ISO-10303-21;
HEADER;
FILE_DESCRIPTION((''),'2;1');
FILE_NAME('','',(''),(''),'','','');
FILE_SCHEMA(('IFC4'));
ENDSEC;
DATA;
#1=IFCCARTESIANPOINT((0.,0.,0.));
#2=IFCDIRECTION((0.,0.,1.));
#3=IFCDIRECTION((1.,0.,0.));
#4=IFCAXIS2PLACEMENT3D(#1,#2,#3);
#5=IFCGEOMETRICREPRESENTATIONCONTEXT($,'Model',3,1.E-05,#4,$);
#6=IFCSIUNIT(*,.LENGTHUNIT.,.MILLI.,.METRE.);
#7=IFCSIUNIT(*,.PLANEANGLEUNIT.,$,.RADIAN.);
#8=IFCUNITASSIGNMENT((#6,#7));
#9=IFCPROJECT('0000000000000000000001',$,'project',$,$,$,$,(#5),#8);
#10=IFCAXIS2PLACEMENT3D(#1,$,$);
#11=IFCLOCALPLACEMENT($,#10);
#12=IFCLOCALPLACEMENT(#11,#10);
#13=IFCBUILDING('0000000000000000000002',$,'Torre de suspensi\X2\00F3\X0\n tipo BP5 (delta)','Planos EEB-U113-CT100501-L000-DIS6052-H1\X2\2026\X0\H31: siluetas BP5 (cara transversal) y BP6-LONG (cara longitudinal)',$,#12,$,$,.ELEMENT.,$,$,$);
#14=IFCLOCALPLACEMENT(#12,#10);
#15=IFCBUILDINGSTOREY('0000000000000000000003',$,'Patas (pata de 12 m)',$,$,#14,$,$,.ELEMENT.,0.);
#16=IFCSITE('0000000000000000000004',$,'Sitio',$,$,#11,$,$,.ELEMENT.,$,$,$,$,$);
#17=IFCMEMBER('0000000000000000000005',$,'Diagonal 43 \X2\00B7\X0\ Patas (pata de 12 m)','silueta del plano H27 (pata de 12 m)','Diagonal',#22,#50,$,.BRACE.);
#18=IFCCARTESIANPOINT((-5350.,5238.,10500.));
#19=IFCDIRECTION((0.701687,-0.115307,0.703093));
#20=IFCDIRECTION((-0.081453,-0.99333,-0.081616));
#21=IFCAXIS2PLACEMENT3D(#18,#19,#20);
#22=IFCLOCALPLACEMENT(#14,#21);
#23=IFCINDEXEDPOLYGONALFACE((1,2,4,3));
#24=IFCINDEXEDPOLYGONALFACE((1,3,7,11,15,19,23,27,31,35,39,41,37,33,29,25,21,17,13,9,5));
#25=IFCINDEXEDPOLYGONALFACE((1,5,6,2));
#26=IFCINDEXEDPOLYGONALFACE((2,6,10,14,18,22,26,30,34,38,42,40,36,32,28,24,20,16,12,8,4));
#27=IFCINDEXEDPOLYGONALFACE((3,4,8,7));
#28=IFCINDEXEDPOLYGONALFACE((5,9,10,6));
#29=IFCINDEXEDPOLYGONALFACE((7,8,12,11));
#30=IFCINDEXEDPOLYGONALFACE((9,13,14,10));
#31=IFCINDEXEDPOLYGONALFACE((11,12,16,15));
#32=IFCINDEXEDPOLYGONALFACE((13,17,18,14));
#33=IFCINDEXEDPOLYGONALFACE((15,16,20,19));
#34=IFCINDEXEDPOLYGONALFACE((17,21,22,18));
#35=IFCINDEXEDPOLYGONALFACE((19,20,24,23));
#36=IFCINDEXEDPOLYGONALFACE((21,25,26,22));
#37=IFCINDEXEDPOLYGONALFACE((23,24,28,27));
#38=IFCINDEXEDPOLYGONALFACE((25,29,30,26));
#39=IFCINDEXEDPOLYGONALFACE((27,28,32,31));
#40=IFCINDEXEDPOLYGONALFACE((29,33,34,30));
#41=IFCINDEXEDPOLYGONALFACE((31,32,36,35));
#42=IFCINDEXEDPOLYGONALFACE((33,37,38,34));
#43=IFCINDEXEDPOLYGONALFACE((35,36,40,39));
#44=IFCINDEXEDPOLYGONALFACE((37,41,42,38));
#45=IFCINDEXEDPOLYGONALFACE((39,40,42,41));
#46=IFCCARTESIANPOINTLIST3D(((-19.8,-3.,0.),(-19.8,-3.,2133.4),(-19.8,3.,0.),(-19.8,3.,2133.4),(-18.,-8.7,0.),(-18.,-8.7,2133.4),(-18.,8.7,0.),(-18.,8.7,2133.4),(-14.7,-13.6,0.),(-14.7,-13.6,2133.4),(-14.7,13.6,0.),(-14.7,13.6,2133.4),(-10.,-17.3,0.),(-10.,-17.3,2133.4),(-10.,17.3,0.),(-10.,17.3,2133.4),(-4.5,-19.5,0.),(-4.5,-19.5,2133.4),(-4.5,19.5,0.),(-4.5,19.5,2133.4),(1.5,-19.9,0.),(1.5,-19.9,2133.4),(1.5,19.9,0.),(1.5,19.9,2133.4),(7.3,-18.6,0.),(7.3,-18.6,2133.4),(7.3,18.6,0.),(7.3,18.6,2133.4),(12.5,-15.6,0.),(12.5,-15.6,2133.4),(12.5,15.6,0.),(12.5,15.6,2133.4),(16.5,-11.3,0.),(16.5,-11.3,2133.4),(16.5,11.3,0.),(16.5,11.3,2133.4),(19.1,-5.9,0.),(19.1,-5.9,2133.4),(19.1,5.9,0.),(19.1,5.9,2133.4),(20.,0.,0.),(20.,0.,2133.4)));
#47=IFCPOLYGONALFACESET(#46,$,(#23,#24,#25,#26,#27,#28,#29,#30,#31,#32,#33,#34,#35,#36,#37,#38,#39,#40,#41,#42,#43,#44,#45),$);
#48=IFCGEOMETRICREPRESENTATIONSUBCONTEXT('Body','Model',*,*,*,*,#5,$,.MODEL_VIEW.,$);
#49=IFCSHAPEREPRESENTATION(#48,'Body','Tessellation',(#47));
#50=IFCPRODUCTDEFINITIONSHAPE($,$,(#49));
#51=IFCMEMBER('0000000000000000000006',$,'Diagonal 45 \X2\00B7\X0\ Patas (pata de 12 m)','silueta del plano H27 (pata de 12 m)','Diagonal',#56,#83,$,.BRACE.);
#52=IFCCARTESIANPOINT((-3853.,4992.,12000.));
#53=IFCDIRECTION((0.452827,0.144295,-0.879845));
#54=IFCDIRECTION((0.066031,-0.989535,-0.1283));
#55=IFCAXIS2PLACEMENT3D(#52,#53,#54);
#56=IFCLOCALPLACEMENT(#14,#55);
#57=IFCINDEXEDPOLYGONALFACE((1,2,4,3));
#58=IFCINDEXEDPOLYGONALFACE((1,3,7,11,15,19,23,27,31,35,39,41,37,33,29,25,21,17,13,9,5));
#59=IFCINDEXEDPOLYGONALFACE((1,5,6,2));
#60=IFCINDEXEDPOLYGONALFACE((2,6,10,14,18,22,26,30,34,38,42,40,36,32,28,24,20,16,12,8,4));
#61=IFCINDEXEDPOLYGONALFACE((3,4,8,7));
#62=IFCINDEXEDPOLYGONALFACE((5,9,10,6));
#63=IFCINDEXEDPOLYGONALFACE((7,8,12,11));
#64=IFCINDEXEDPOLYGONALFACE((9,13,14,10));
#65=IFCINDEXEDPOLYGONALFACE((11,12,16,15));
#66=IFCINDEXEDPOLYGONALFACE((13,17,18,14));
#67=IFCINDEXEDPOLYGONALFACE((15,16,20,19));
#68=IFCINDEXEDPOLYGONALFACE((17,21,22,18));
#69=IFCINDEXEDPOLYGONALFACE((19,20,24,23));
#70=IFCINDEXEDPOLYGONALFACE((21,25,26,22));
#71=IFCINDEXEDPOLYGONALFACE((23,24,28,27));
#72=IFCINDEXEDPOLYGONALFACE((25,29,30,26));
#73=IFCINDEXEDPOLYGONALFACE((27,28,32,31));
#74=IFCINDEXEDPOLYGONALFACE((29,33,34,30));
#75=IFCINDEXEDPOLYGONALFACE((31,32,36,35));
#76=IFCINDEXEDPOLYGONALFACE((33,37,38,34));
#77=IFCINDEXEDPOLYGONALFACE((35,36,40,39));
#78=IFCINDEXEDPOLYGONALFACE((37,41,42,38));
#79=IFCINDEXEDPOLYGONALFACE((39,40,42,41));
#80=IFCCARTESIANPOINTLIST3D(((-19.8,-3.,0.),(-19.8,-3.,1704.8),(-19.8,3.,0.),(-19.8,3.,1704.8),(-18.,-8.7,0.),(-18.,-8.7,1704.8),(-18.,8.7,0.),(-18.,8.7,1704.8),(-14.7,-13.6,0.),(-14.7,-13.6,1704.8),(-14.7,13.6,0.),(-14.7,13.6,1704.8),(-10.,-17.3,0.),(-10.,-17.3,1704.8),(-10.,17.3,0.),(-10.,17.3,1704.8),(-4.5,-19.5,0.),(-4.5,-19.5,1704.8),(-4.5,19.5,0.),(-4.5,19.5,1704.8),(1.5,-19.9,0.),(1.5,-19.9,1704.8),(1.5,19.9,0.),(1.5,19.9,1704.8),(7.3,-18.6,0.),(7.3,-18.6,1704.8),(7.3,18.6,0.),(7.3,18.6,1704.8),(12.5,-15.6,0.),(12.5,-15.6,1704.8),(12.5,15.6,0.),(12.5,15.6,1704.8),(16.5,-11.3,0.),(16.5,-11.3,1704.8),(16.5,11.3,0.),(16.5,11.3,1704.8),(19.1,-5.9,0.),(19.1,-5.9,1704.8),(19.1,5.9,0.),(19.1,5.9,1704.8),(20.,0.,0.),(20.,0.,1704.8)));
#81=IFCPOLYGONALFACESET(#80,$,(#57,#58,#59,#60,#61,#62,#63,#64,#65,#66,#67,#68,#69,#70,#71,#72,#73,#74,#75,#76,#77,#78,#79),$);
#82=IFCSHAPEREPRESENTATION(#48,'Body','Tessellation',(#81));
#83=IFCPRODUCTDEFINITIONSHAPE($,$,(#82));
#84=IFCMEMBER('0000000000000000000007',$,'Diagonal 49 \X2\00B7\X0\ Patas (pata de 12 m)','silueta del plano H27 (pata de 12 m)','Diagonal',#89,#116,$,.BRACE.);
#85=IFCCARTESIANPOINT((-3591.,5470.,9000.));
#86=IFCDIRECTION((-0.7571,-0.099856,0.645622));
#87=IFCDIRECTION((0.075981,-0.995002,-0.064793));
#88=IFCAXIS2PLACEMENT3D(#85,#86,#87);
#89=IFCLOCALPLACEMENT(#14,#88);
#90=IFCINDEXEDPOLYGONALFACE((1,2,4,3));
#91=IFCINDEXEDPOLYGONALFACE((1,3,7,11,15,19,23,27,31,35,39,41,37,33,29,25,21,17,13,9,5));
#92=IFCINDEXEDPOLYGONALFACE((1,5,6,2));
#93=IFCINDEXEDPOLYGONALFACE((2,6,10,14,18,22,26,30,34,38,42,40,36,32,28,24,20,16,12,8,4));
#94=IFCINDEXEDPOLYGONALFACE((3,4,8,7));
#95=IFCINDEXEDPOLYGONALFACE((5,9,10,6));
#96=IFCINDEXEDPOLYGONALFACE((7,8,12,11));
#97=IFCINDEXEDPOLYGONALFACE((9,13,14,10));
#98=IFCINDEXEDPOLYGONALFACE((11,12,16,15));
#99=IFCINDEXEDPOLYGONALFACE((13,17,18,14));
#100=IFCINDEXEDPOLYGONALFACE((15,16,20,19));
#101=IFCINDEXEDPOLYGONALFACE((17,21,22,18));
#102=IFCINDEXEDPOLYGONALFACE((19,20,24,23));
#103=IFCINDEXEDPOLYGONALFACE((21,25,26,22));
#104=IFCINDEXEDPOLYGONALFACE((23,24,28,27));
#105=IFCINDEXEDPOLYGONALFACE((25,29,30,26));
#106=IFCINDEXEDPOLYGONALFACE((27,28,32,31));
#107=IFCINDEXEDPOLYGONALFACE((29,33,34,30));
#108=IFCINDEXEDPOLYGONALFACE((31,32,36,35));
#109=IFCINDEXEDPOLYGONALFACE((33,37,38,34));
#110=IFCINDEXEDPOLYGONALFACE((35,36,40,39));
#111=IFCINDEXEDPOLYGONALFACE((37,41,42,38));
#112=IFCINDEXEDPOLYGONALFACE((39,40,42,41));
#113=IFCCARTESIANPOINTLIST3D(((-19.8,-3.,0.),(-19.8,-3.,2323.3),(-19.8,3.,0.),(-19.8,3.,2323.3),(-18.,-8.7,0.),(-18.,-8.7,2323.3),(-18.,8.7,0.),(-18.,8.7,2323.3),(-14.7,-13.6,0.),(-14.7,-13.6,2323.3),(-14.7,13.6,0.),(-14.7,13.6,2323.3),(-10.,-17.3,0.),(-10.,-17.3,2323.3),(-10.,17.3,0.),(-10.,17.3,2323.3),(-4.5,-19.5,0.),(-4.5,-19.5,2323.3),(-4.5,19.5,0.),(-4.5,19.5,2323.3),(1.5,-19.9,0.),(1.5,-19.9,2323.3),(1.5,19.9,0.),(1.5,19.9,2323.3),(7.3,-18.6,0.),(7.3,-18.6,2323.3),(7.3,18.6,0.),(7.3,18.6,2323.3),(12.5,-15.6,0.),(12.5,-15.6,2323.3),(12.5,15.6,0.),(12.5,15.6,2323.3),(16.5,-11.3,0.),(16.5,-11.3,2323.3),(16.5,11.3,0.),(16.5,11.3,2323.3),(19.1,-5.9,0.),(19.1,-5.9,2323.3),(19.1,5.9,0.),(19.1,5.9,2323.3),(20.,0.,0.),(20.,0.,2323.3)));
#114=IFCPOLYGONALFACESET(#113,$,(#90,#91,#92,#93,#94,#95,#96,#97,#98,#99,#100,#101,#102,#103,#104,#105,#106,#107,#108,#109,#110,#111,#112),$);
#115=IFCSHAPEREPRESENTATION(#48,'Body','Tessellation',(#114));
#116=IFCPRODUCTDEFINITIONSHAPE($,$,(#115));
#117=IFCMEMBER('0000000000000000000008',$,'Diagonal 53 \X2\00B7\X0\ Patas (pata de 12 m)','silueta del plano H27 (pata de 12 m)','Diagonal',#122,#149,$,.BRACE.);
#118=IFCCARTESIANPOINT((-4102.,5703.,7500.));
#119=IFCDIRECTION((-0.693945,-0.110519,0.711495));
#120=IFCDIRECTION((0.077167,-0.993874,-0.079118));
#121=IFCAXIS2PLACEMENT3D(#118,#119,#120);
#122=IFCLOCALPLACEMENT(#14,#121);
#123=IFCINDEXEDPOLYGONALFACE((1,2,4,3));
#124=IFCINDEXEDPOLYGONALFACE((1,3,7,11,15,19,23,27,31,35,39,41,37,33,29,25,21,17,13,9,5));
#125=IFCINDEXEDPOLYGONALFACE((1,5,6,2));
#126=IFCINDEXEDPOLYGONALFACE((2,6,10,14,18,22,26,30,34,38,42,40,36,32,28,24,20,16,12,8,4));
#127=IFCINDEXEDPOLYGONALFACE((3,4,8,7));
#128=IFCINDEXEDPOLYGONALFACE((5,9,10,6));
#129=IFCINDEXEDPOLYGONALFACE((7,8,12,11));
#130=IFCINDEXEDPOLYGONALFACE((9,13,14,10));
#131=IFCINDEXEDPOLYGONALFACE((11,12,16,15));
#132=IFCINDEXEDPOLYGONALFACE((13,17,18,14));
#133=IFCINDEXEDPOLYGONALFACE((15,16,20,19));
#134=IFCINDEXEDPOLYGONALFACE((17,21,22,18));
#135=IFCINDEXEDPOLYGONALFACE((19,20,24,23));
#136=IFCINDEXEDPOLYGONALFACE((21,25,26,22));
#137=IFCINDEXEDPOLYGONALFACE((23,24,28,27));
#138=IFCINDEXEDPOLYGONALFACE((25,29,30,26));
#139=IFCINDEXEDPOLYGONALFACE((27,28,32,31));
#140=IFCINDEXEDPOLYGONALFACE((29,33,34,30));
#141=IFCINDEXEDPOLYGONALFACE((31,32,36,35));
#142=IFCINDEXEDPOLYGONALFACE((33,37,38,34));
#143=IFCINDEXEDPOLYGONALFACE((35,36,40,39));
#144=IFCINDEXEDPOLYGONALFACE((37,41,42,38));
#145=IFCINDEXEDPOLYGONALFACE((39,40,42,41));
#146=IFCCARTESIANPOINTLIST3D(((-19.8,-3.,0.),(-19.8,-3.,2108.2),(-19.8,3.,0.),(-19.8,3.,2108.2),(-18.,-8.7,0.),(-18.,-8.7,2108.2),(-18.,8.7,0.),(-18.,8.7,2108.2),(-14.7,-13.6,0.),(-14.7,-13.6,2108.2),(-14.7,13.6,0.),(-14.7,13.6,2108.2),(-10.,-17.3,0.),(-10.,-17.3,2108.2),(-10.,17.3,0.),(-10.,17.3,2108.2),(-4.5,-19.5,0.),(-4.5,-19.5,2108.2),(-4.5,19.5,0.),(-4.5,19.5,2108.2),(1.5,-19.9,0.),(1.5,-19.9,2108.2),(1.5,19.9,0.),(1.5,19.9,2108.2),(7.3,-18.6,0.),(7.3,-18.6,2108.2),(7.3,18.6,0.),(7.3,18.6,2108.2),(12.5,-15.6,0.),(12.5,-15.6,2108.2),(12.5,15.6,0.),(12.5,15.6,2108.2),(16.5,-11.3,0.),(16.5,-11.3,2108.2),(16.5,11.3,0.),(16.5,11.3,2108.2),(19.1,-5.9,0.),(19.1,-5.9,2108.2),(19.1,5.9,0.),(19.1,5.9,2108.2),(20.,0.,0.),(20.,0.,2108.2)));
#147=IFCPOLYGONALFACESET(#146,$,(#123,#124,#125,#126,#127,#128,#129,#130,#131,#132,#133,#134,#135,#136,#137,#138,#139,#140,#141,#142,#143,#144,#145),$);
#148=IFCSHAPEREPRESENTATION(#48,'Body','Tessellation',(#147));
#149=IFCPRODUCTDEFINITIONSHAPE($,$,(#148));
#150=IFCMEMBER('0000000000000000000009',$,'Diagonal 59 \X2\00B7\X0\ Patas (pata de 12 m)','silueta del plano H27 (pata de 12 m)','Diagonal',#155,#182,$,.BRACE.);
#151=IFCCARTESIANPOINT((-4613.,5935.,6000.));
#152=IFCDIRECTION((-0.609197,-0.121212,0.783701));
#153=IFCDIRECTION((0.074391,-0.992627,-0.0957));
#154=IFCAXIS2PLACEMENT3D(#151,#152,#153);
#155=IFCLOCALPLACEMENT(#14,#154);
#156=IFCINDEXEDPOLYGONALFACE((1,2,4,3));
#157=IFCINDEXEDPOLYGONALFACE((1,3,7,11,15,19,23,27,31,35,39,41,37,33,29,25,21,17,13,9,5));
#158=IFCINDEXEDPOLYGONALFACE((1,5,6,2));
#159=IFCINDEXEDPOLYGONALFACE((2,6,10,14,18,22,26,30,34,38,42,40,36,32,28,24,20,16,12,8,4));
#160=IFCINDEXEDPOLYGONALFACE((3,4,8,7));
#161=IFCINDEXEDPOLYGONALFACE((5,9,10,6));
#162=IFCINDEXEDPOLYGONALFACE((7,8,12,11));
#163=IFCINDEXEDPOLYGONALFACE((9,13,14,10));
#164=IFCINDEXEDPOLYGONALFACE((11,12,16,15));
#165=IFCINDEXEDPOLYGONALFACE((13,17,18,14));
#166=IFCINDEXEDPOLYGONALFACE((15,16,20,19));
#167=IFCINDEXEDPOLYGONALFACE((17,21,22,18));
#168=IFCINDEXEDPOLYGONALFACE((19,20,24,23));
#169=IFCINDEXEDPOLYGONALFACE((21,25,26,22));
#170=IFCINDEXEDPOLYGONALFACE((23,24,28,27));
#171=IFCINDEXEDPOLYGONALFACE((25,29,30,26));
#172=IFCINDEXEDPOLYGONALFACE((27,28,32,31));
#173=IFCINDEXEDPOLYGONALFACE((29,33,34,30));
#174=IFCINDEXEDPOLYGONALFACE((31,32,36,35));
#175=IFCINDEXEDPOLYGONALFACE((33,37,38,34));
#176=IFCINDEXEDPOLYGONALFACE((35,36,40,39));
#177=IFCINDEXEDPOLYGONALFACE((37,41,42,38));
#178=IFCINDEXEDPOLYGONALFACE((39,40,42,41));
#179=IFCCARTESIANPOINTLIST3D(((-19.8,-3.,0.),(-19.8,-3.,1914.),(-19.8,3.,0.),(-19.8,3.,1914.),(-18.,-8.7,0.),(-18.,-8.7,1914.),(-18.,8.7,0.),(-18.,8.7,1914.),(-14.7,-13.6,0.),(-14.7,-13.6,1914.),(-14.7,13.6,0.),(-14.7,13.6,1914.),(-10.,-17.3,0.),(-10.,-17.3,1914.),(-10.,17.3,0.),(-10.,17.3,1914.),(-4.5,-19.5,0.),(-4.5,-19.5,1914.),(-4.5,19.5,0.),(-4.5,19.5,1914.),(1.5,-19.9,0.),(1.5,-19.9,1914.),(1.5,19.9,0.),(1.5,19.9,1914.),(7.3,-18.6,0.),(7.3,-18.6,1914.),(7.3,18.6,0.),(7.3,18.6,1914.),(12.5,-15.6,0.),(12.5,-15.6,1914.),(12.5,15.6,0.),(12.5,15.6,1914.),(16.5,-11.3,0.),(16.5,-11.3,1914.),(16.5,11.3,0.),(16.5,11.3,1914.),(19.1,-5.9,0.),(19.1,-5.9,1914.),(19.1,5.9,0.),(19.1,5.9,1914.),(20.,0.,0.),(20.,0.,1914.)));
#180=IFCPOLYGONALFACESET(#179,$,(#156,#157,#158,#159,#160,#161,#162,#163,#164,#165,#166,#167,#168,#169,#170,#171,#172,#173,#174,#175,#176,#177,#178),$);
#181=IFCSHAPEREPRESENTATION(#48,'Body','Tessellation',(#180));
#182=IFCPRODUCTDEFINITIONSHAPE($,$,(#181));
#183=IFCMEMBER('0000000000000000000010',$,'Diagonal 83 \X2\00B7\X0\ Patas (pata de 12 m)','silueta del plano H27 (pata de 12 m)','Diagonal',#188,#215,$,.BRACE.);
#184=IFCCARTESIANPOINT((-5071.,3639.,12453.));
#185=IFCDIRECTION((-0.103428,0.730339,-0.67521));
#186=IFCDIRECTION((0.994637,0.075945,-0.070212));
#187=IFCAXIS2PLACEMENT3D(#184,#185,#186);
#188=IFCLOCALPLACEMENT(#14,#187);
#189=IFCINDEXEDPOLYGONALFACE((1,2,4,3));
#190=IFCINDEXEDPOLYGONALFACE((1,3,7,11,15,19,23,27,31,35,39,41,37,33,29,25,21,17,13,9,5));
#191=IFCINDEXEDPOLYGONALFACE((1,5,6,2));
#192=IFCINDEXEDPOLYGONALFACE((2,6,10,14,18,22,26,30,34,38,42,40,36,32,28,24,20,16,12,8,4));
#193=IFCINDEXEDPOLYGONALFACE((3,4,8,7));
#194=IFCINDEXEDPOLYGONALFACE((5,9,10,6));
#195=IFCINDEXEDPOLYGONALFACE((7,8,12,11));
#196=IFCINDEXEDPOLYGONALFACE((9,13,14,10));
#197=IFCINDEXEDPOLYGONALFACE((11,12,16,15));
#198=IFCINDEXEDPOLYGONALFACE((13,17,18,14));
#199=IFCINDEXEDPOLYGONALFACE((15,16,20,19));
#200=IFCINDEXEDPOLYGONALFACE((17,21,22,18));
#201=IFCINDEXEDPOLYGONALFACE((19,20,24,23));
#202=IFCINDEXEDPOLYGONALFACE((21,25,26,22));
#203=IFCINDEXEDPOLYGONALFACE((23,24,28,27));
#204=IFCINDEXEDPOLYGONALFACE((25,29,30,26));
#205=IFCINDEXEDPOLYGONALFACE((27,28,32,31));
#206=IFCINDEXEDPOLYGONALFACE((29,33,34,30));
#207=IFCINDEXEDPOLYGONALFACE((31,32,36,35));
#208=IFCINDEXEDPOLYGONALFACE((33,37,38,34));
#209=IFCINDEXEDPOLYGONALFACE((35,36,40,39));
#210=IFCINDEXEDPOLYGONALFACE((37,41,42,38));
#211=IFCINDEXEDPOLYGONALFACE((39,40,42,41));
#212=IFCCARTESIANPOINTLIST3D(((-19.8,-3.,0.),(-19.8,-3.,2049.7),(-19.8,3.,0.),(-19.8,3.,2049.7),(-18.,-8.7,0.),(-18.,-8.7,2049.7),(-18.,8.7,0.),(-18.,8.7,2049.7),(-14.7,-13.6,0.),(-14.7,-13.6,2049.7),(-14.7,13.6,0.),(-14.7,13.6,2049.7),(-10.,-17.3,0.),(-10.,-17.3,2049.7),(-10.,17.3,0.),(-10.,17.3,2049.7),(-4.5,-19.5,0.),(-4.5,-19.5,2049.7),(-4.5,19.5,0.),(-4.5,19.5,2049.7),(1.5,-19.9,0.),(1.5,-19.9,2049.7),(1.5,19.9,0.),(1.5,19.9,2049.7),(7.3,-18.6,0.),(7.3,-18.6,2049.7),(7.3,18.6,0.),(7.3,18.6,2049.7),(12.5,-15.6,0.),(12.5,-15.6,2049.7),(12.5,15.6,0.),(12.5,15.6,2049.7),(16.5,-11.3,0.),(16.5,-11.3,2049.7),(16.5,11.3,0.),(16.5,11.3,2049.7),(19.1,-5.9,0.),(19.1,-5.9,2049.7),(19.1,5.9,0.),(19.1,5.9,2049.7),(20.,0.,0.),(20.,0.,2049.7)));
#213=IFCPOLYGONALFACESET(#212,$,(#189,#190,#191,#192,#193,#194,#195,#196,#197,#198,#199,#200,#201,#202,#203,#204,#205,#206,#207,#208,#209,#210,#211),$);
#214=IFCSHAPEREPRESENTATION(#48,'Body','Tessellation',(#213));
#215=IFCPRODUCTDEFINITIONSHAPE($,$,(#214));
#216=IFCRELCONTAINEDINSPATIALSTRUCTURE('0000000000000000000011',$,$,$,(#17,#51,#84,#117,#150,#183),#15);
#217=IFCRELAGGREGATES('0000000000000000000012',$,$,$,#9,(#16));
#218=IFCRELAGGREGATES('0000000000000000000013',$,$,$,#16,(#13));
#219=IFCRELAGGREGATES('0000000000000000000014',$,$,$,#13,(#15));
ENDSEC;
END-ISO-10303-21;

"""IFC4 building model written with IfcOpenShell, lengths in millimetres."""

from ifc_helpers import new_model, si_unit, frame, origin, origin_with_axes, place, context, subcontext, project, spatial, circle, extrude, element, save


model = new_model("IFC4")

# Units and contexts
model_context = context("Model", 3, precision=1e-05, world=origin_with_axes())
body_context = subcontext(model_context, "Body", "Model", "MODEL_VIEW")
ifc_project = project(units=[si_unit("LENGTHUNIT", "METRE", prefix="MILLI"), si_unit("PLANEANGLEUNIT", "RADIAN")], contexts=[model_context])

# Site, building, storey
site_placement = place(None, origin())
site = spatial("IfcSite", under=ifc_project, at=site_placement, Name="Sitio", CompositionType="ELEMENT")
building_placement = place(site_placement, origin())
building = spatial("IfcBuilding", under=site, at=building_placement, Name="Torre de suspensión tipo BP5 (delta)", Description="Planos EEB-U113-CT100501-L000-DIS6052-H1…H31: siluetas BP5 (cara transversal) y BP6-LONG (cara longitudinal)", CompositionType="ELEMENT")
storey_placement = place(building_placement, origin())
storey = spatial("IfcBuildingStorey", under=building, at=storey_placement, Name="Patas (pata de 12 m)", CompositionType="ELEMENT", Elevation=0.0)

# Members
member_1_placement = place(storey_placement, frame((-5350.0, 5238.0, 10500.0), z_axis=(0.701687, -0.115307, 0.703093), x_axis=(-0.081453, -0.99333, -0.081616)))
element("IfcMember", 1, at=member_1_placement, inside=storey, Name="Diagonal 43 · Patas (pata de 12 m)", Description="silueta del plano H27 (pata de 12 m)", ObjectType="Diagonal", PredefinedType="BRACE", context=body_context, shape_type="SweptSolid", body=[
    extrude(circle(Radius=20.0), None, (0.0, 0.0, 1.0), 2133.4),
])
member_2_placement = place(storey_placement, frame((-3853.0, 4992.0, 12000.0), z_axis=(0.452827, 0.144295, -0.879845), x_axis=(0.066031, -0.989535, -0.1283)))
element("IfcMember", 2, at=member_2_placement, inside=storey, Name="Diagonal 45 · Patas (pata de 12 m)", Description="silueta del plano H27 (pata de 12 m)", ObjectType="Diagonal", PredefinedType="BRACE", context=body_context, shape_type="SweptSolid", body=[
    extrude(circle(Radius=20.0), None, (0.0, 0.0, 1.0), 1704.8),
])
member_3_placement = place(storey_placement, frame((-3591.0, 5470.0, 9000.0), z_axis=(-0.7571, -0.099856, 0.645622), x_axis=(0.075981, -0.995002, -0.064793)))
element("IfcMember", 3, at=member_3_placement, inside=storey, Name="Diagonal 49 · Patas (pata de 12 m)", Description="silueta del plano H27 (pata de 12 m)", ObjectType="Diagonal", PredefinedType="BRACE", context=body_context, shape_type="SweptSolid", body=[
    extrude(circle(Radius=20.0), None, (0.0, 0.0, 1.0), 2323.3),
])
member_4_placement = place(storey_placement, frame((-4102.0, 5703.0, 7500.0), z_axis=(-0.693945, -0.110519, 0.711495), x_axis=(0.077167, -0.993874, -0.079118)))
element("IfcMember", 4, at=member_4_placement, inside=storey, Name="Diagonal 53 · Patas (pata de 12 m)", Description="silueta del plano H27 (pata de 12 m)", ObjectType="Diagonal", PredefinedType="BRACE", context=body_context, shape_type="SweptSolid", body=[
    extrude(circle(Radius=20.0), None, (0.0, 0.0, 1.0), 2108.2),
])
member_5_placement = place(storey_placement, frame((-4613.0, 5935.0, 6000.0), z_axis=(-0.609197, -0.121212, 0.783701), x_axis=(0.074391, -0.992627, -0.0957)))
element("IfcMember", 5, at=member_5_placement, inside=storey, Name="Diagonal 59 · Patas (pata de 12 m)", Description="silueta del plano H27 (pata de 12 m)", ObjectType="Diagonal", PredefinedType="BRACE", context=body_context, shape_type="SweptSolid", body=[
    extrude(circle(Radius=20.0), None, (0.0, 0.0, 1.0), 1914.0),
])
member_6_placement = place(storey_placement, frame((-5071.0, 3639.0, 12453.0), z_axis=(-0.103428, 0.730339, -0.67521), x_axis=(0.994637, 0.075945, -0.070212)))
element("IfcMember", 6, at=member_6_placement, inside=storey, Name="Diagonal 83 · Patas (pata de 12 m)", Description="silueta del plano H27 (pata de 12 m)", ObjectType="Diagonal", PredefinedType="BRACE", context=body_context, shape_type="SweptSolid", body=[
    extrude(circle(Radius=20.0), None, (0.0, 0.0, 1.0), 2049.7),
])

save(model, "model.ifc")
